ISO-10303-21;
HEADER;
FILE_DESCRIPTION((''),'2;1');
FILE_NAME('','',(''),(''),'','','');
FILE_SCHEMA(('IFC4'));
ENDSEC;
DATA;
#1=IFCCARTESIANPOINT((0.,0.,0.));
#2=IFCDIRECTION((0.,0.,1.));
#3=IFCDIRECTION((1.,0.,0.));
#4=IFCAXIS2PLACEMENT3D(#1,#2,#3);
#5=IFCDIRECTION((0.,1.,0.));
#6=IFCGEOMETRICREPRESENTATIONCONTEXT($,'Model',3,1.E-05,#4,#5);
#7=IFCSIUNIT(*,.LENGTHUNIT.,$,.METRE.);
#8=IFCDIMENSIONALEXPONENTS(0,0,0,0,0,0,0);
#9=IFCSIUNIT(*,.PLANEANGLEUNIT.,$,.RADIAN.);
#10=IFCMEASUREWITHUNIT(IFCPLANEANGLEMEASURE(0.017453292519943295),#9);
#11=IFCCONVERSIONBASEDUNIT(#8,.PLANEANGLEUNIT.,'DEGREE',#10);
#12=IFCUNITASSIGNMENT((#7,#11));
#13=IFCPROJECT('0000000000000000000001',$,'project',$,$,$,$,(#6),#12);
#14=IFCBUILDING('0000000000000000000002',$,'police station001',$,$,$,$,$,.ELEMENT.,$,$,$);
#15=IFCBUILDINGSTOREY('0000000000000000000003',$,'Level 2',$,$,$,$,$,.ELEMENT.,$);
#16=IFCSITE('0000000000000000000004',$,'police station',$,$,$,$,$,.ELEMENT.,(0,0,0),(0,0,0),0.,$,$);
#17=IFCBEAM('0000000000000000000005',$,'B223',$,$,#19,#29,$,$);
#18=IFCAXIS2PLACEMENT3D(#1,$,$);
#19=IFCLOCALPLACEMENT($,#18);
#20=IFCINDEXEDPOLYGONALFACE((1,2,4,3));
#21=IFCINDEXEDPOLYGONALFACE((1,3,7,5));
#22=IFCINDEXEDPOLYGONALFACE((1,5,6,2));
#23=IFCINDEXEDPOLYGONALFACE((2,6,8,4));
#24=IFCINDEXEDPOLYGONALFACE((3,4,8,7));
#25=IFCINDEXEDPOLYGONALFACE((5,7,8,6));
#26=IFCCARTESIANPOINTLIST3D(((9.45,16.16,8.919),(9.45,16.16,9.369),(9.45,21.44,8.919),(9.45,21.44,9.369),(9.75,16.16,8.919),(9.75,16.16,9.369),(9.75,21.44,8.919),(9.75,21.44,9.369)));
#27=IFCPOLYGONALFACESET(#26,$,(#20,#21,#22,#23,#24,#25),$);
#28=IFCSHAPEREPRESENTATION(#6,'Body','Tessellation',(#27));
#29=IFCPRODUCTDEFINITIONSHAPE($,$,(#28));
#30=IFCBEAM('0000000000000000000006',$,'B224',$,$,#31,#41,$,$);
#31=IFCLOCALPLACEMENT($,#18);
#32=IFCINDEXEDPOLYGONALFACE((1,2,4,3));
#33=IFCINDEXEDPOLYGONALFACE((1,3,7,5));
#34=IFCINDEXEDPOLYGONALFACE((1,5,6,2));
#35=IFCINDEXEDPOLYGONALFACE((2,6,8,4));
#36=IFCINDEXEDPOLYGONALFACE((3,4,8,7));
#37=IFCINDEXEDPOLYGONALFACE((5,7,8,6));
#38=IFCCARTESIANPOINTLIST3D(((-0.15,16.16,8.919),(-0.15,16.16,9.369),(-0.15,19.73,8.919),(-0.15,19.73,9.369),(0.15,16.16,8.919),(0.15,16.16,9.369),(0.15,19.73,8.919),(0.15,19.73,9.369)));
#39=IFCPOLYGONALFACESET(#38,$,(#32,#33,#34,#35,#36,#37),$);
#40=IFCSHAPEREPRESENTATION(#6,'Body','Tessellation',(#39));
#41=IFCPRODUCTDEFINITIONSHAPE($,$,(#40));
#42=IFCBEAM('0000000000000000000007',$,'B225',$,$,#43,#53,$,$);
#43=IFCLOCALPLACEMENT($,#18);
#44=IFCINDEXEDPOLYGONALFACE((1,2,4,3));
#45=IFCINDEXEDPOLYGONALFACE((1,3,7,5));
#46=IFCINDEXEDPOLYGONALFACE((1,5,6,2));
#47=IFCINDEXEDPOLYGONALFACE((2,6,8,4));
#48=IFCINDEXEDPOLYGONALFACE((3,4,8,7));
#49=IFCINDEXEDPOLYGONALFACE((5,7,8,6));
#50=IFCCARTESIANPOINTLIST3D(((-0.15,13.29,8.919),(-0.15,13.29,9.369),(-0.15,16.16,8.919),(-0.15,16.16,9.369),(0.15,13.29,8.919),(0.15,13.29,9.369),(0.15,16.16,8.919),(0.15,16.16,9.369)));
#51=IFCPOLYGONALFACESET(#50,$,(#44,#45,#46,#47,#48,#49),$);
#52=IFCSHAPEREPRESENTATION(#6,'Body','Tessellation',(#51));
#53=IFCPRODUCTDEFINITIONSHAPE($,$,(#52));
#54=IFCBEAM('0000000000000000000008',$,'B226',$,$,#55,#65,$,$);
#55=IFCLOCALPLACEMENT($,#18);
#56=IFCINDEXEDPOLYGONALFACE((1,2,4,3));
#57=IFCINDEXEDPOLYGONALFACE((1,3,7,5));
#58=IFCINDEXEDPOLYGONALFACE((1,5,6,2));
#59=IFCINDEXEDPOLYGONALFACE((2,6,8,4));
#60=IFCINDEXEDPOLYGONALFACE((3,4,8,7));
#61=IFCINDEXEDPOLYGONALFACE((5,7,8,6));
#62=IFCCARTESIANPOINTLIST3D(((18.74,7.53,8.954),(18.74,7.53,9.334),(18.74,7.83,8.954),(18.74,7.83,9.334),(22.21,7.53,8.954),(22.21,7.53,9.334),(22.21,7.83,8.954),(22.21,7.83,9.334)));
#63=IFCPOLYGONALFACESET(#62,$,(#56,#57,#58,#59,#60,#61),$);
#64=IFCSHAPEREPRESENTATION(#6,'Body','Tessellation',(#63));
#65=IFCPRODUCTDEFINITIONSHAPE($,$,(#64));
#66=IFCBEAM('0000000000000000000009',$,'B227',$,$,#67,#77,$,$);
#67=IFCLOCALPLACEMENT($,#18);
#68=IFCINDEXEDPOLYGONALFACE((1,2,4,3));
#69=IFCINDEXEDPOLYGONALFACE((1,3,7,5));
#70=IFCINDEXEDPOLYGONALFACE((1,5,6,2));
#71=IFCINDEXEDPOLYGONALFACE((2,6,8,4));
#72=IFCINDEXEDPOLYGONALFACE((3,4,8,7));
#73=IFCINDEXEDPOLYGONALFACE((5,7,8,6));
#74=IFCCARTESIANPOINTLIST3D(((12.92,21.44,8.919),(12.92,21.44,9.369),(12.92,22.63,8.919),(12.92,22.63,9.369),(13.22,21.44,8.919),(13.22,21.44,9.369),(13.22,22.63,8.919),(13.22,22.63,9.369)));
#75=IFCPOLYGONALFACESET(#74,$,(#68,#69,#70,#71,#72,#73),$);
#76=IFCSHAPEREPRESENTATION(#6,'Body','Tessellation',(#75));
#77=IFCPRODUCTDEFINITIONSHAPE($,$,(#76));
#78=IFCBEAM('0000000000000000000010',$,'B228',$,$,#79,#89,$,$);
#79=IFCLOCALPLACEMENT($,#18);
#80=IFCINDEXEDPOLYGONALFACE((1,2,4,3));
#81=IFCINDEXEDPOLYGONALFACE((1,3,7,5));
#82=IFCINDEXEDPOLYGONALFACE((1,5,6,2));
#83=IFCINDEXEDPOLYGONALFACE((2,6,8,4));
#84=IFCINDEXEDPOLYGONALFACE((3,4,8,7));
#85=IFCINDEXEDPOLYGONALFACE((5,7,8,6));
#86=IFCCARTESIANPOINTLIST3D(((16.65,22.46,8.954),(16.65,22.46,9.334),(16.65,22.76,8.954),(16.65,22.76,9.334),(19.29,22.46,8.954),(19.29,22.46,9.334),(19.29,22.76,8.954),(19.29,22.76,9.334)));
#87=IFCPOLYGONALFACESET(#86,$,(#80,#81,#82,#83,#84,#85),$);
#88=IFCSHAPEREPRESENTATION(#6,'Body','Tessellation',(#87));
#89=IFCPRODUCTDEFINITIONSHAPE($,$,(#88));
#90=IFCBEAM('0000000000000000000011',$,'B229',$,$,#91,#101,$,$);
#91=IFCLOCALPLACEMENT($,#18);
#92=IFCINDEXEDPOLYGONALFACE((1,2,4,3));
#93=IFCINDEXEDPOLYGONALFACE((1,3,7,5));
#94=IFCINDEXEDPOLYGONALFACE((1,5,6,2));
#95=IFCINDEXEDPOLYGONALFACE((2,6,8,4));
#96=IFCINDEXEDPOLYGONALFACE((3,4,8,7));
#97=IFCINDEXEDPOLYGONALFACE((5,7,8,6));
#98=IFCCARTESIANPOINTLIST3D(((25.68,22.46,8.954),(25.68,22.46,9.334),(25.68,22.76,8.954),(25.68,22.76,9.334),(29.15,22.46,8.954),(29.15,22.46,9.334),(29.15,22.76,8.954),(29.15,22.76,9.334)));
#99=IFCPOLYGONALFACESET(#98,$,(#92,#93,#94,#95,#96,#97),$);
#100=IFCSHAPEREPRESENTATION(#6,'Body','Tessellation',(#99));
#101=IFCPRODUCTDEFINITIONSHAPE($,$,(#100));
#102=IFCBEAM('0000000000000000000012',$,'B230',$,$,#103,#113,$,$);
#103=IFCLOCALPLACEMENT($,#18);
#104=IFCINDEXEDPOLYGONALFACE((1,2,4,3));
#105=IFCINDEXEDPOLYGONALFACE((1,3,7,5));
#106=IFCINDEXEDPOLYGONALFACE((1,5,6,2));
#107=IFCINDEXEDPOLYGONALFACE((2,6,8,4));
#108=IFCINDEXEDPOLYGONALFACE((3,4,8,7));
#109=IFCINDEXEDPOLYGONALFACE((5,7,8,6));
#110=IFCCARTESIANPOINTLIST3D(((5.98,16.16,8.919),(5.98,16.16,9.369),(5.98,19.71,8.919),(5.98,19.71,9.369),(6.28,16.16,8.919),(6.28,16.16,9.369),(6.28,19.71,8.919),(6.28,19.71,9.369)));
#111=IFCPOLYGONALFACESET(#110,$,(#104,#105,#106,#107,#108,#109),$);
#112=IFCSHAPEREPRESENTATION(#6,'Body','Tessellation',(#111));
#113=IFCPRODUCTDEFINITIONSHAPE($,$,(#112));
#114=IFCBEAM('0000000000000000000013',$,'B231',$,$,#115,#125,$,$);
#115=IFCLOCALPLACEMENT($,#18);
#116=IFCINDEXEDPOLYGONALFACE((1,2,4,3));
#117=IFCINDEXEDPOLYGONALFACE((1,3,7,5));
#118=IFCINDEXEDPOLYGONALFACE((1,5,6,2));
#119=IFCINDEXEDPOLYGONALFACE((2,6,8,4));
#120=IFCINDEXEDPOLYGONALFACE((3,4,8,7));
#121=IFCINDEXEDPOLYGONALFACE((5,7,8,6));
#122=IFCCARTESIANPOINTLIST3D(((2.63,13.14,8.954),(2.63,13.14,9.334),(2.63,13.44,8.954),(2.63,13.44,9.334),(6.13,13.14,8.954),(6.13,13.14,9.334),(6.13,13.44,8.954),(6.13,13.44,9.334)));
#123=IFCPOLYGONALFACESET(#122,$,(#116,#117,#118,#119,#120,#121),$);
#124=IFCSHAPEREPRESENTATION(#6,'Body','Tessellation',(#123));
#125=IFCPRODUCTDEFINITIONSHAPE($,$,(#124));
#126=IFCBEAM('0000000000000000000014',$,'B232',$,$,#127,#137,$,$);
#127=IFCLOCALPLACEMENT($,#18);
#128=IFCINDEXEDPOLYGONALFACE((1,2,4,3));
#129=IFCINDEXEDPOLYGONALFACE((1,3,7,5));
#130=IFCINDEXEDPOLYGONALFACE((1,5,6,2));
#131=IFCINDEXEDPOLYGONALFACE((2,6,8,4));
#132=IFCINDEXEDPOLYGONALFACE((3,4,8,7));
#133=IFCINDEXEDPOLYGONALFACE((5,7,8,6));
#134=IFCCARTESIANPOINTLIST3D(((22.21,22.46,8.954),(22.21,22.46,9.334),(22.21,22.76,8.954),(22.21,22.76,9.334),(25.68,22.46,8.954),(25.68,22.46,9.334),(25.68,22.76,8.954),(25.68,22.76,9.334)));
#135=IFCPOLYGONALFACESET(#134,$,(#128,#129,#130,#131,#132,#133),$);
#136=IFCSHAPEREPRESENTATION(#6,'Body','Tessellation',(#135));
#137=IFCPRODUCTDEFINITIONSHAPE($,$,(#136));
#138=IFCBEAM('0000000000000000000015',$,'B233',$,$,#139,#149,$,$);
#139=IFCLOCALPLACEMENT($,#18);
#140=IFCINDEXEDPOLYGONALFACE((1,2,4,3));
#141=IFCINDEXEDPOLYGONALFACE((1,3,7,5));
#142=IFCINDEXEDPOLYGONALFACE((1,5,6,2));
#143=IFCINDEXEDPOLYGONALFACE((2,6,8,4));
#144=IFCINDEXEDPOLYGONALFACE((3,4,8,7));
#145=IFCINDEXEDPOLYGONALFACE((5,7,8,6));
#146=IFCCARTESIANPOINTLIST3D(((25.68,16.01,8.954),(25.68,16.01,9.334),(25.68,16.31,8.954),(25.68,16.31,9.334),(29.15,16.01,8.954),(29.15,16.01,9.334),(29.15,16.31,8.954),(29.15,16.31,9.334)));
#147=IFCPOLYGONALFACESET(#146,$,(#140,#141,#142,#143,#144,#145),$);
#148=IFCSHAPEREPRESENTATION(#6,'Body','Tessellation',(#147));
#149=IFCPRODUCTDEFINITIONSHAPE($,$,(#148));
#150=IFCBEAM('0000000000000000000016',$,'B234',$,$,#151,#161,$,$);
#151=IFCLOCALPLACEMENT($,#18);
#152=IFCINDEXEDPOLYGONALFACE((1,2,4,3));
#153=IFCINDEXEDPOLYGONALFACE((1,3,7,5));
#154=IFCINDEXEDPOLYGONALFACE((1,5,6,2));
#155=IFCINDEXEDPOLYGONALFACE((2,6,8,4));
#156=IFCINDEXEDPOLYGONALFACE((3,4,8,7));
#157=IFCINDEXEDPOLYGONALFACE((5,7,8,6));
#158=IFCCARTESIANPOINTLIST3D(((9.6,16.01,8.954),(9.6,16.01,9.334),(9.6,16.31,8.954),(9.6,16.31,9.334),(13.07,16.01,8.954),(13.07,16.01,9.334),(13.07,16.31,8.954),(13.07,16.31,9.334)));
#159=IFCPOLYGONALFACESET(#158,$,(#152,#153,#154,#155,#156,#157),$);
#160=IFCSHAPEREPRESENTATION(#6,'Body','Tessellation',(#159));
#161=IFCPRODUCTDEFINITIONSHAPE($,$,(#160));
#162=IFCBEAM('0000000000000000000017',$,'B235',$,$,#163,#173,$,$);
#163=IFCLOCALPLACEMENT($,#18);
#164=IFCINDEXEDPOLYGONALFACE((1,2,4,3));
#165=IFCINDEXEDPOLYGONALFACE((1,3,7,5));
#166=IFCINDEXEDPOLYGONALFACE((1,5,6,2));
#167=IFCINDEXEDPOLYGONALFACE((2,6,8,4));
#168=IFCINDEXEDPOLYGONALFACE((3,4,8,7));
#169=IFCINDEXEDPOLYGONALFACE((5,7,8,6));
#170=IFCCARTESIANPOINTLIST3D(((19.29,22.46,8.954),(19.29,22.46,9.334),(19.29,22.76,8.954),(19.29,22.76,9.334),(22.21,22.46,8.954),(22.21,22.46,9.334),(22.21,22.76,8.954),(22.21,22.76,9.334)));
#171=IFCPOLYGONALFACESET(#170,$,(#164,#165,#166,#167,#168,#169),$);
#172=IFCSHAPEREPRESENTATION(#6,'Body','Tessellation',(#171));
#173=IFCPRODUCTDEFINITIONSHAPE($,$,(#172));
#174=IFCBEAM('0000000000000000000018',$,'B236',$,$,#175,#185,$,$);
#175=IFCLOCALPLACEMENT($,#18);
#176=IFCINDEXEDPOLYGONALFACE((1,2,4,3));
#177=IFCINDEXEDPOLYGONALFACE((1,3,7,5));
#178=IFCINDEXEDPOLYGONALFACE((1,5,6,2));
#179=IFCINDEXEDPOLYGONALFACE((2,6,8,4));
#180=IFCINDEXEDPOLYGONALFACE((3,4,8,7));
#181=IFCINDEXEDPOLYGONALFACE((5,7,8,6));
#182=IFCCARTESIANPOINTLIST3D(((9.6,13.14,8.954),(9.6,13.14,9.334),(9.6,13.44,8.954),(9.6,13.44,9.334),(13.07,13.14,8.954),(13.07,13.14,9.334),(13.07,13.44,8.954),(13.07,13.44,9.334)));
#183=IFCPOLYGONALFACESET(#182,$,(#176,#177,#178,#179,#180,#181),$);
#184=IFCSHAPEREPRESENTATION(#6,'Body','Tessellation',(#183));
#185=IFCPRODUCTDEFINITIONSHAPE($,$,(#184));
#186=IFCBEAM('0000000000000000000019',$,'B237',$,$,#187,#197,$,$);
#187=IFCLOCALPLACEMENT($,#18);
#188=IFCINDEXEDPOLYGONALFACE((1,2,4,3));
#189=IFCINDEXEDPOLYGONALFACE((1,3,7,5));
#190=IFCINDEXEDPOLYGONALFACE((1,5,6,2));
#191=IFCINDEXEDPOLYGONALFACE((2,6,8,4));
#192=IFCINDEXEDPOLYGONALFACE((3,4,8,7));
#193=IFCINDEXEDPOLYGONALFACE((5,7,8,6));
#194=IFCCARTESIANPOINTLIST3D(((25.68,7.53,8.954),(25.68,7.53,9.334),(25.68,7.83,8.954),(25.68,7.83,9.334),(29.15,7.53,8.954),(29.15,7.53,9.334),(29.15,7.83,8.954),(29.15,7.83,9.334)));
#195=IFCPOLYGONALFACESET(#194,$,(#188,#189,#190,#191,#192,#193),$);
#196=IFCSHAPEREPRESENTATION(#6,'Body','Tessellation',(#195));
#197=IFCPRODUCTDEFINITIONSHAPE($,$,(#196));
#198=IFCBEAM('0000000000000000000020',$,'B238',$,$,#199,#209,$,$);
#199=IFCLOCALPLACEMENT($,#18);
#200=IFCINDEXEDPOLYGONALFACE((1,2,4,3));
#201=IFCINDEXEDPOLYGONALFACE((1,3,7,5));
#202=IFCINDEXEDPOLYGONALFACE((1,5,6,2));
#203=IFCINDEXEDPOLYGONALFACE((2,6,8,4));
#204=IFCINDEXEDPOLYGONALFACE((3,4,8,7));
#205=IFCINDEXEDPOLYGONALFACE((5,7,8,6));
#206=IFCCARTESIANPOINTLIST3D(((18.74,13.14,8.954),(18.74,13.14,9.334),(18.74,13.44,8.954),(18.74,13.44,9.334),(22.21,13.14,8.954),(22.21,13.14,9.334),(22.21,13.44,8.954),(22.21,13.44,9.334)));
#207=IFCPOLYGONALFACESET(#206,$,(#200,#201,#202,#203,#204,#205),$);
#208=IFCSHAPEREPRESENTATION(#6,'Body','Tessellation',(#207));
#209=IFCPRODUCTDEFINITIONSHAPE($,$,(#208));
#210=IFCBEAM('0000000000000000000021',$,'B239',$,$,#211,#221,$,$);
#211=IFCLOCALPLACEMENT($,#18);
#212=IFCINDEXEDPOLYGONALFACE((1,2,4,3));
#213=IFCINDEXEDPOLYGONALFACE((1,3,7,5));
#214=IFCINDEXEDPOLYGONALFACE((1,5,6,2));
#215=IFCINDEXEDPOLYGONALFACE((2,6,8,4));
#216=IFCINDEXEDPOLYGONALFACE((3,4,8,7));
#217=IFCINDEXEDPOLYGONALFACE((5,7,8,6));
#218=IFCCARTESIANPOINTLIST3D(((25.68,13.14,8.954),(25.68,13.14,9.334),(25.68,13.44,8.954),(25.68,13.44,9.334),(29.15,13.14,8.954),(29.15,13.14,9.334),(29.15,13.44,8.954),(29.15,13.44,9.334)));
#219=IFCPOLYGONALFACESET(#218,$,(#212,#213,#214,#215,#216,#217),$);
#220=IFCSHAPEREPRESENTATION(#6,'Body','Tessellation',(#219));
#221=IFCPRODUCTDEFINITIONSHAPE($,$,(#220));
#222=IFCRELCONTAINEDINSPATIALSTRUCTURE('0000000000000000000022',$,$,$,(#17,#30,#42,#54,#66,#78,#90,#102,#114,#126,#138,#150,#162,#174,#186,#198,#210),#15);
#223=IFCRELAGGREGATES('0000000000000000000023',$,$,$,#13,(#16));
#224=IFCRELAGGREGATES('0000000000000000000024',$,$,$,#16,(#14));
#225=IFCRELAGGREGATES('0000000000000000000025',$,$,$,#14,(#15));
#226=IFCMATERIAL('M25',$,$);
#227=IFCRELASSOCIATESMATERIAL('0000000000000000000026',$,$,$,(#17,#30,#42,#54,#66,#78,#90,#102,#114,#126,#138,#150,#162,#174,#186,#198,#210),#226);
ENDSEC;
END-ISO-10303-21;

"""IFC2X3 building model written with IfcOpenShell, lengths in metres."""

from ifc_helpers import new_model, entity, si_unit, converted_unit, direction, frame, frame_2d, origin_with_axes, place, context, project, spatial, rectangle, extrude, material, element, save


model = new_model("IFC2X3")

# Units and contexts
model_context = context("Model", 3, precision=1e-05, world=origin_with_axes(), true_north=direction((0.0, 1.0, 0.0)))
ifc_project = project(units=[si_unit("LENGTHUNIT", "METRE"), converted_unit("PLANEANGLEUNIT", "DEGREE", entity("IfcPlaneAngleMeasure", 0.017453292519943295), si_unit("PLANEANGLEUNIT", "RADIAN"), dimensions=[0, 0, 0, 0, 0, 0, 0])], contexts=[model_context])

# Site, building, storey
site = spatial("IfcSite", under=ifc_project, Name="police station", CompositionType="ELEMENT", RefLatitude=(0, 0, 0), RefLongitude=(0, 0, 0), RefElevation=0.0)
building = spatial("IfcBuilding", under=site, Name="police station001", CompositionType="ELEMENT")
storey = spatial("IfcBuildingStorey", under=building, Name="Level 2", CompositionType="ELEMENT")

# Beams
ifc_material = material(Name="M25")
placement = place(None, origin_with_axes())
element("IfcBeam", 1, at=placement, inside=storey, material=ifc_material, Name="B223", context=model_context, shape_type="SweptSolid", body=[
    extrude(rectangle(XDim=0.3, YDim=0.45, at=frame_2d((0.0, 0.0), x_axis=(0.0, 1.0, 0.0))), frame((9.6, 16.16, 9.144), z_axis=(0.0, 1.0, 0.0), x_axis=(0.0, 0.0, -1.0)), (0.0, 0.0, 1.0), 5.28),
])
element("IfcBeam", 2, at=placement, inside=storey, material=ifc_material, Name="B224", context=model_context, shape_type="SweptSolid", body=[
    extrude(rectangle(XDim=0.3, YDim=0.45, at=frame_2d((0.0, 0.0), x_axis=(0.0, 1.0, 0.0))), frame((0.0, 19.73, 9.144), z_axis=(0.0, -1.0, 0.0), x_axis=(0.0, 0.0, -1.0)), (0.0, 0.0, 1.0), 3.57),
])
element("IfcBeam", 3, at=placement, inside=storey, material=ifc_material, Name="B225", context=model_context, shape_type="SweptSolid", body=[
    extrude(rectangle(XDim=0.3, YDim=0.45, at=frame_2d((0.0, 0.0), x_axis=(0.0, 1.0, 0.0))), frame((0.0, 13.29, 9.144), z_axis=(0.0, 1.0, 0.0), x_axis=(0.0, 0.0, -1.0)), (0.0, 0.0, 1.0), 2.87),
])
element("IfcBeam", 4, at=placement, inside=storey, material=ifc_material, Name="B226", context=model_context, shape_type="SweptSolid", body=[
    extrude(rectangle(XDim=0.3, YDim=0.38, at=frame_2d((0.0, 0.0), x_axis=(0.0, 1.0, 0.0))), frame((18.74, 7.68, 9.144), z_axis=(1.0, 0.0, 0.0), x_axis=(0.0, 0.0, -1.0)), (0.0, 0.0, 1.0), 3.47),
])
element("IfcBeam", 5, at=placement, inside=storey, material=ifc_material, Name="B227", context=model_context, shape_type="SweptSolid", body=[
    extrude(rectangle(XDim=0.3, YDim=0.45, at=frame_2d((0.0, 0.0), x_axis=(0.0, 1.0, 0.0))), frame((13.07, 21.44, 9.144), z_axis=(0.0, 1.0, 0.0), x_axis=(0.0, 0.0, -1.0)), (0.0, 0.0, 1.0), 1.19),
])
element("IfcBeam", 6, at=placement, inside=storey, material=ifc_material, Name="B228", context=model_context, shape_type="SweptSolid", body=[
    extrude(rectangle(XDim=0.3, YDim=0.38, at=frame_2d((0.0, 0.0), x_axis=(0.0, 1.0, 0.0))), frame((19.29, 22.61, 9.144), z_axis=(-1.0, 0.0, 0.0), x_axis=(0.0, 0.0, -1.0)), (0.0, 0.0, 1.0), 2.64),
])
element("IfcBeam", 7, at=placement, inside=storey, material=ifc_material, Name="B229", context=model_context, shape_type="SweptSolid", body=[
    extrude(rectangle(XDim=0.3, YDim=0.38, at=frame_2d((0.0, 0.0), x_axis=(0.0, 1.0, 0.0))), frame((29.15, 22.61, 9.144), z_axis=(-1.0, 0.0, 0.0), x_axis=(0.0, 0.0, -1.0)), (0.0, 0.0, 1.0), 3.47),
])
element("IfcBeam", 8, at=placement, inside=storey, material=ifc_material, Name="B230", context=model_context, shape_type="SweptSolid", body=[
    extrude(rectangle(XDim=0.3, YDim=0.45, at=frame_2d((0.0, 0.0), x_axis=(0.0, 1.0, 0.0))), frame((6.13, 16.16, 9.144), z_axis=(0.0, 1.0, 0.0), x_axis=(0.0, 0.0, -1.0)), (0.0, 0.0, 1.0), 3.55),
])
element("IfcBeam", 9, at=placement, inside=storey, material=ifc_material, Name="B231", context=model_context, shape_type="SweptSolid", body=[
    extrude(rectangle(XDim=0.3, YDim=0.38, at=frame_2d((0.0, 0.0), x_axis=(0.0, 1.0, 0.0))), frame((2.63, 13.29, 9.144), z_axis=(1.0, 0.0, 0.0), x_axis=(0.0, 0.0, -1.0)), (0.0, 0.0, 1.0), 3.5),
])
element("IfcBeam", 10, at=placement, inside=storey, material=ifc_material, Name="B232", context=model_context, shape_type="SweptSolid", body=[
    extrude(rectangle(XDim=0.3, YDim=0.38, at=frame_2d((0.0, 0.0), x_axis=(0.0, 1.0, 0.0))), frame((25.68, 22.61, 9.144), z_axis=(-1.0, 0.0, 0.0), x_axis=(0.0, 0.0, -1.0)), (0.0, 0.0, 1.0), 3.47),
])
element("IfcBeam", 11, at=placement, inside=storey, material=ifc_material, Name="B233", context=model_context, shape_type="SweptSolid", body=[
    extrude(rectangle(XDim=0.3, YDim=0.38, at=frame_2d((0.0, 0.0), x_axis=(0.0, 1.0, 0.0))), frame((25.68, 16.16, 9.144), z_axis=(1.0, 0.0, 0.0), x_axis=(0.0, 0.0, -1.0)), (0.0, 0.0, 1.0), 3.47),
])
element("IfcBeam", 12, at=placement, inside=storey, material=ifc_material, Name="B234", context=model_context, shape_type="SweptSolid", body=[
    extrude(rectangle(XDim=0.3, YDim=0.38, at=frame_2d((0.0, 0.0), x_axis=(0.0, 1.0, 0.0))), frame((13.07, 16.16, 9.144), z_axis=(-1.0, 0.0, 0.0), x_axis=(0.0, 0.0, -1.0)), (0.0, 0.0, 1.0), 3.47),
])
element("IfcBeam", 13, at=placement, inside=storey, material=ifc_material, Name="B235", context=model_context, shape_type="SweptSolid", body=[
    extrude(rectangle(XDim=0.3, YDim=0.38, at=frame_2d((0.0, 0.0), x_axis=(0.0, 1.0, 0.0))), frame((22.21, 22.61, 9.144), z_axis=(-1.0, 0.0, 0.0), x_axis=(0.0, 0.0, -1.0)), (0.0, 0.0, 1.0), 2.92),
])
element("IfcBeam", 14, at=placement, inside=storey, material=ifc_material, Name="B236", context=model_context, shape_type="SweptSolid", body=[
    extrude(rectangle(XDim=0.3, YDim=0.38, at=frame_2d((0.0, 0.0), x_axis=(0.0, 1.0, 0.0))), frame((13.07, 13.29, 9.144), z_axis=(-1.0, 0.0, 0.0), x_axis=(0.0, 0.0, -1.0)), (0.0, 0.0, 1.0), 3.47),
])
element("IfcBeam", 15, at=placement, inside=storey, material=ifc_material, Name="B237", context=model_context, shape_type="SweptSolid", body=[
    extrude(rectangle(XDim=0.3, YDim=0.38, at=frame_2d((0.0, 0.0), x_axis=(0.0, 1.0, 0.0))), frame((25.68, 7.68, 9.144), z_axis=(1.0, 0.0, 0.0), x_axis=(0.0, 0.0, -1.0)), (0.0, 0.0, 1.0), 3.47),
])
element("IfcBeam", 16, at=placement, inside=storey, material=ifc_material, Name="B238", context=model_context, shape_type="SweptSolid", body=[
    extrude(rectangle(XDim=0.3, YDim=0.38, at=frame_2d((0.0, 0.0), x_axis=(0.0, 1.0, 0.0))), frame((22.21, 13.29, 9.144), z_axis=(-1.0, 0.0, 0.0), x_axis=(0.0, 0.0, -1.0)), (0.0, 0.0, 1.0), 3.47),
])
element("IfcBeam", 17, at=placement, inside=storey, material=ifc_material, Name="B239", context=model_context, shape_type="SweptSolid", body=[
    extrude(rectangle(XDim=0.3, YDim=0.38, at=frame_2d((0.0, 0.0), x_axis=(0.0, 1.0, 0.0))), frame((29.15, 13.29, 9.144), z_axis=(-1.0, 0.0, 0.0), x_axis=(0.0, 0.0, -1.0)), (0.0, 0.0, 1.0), 3.47),
])

save(model, "model.ifc")
